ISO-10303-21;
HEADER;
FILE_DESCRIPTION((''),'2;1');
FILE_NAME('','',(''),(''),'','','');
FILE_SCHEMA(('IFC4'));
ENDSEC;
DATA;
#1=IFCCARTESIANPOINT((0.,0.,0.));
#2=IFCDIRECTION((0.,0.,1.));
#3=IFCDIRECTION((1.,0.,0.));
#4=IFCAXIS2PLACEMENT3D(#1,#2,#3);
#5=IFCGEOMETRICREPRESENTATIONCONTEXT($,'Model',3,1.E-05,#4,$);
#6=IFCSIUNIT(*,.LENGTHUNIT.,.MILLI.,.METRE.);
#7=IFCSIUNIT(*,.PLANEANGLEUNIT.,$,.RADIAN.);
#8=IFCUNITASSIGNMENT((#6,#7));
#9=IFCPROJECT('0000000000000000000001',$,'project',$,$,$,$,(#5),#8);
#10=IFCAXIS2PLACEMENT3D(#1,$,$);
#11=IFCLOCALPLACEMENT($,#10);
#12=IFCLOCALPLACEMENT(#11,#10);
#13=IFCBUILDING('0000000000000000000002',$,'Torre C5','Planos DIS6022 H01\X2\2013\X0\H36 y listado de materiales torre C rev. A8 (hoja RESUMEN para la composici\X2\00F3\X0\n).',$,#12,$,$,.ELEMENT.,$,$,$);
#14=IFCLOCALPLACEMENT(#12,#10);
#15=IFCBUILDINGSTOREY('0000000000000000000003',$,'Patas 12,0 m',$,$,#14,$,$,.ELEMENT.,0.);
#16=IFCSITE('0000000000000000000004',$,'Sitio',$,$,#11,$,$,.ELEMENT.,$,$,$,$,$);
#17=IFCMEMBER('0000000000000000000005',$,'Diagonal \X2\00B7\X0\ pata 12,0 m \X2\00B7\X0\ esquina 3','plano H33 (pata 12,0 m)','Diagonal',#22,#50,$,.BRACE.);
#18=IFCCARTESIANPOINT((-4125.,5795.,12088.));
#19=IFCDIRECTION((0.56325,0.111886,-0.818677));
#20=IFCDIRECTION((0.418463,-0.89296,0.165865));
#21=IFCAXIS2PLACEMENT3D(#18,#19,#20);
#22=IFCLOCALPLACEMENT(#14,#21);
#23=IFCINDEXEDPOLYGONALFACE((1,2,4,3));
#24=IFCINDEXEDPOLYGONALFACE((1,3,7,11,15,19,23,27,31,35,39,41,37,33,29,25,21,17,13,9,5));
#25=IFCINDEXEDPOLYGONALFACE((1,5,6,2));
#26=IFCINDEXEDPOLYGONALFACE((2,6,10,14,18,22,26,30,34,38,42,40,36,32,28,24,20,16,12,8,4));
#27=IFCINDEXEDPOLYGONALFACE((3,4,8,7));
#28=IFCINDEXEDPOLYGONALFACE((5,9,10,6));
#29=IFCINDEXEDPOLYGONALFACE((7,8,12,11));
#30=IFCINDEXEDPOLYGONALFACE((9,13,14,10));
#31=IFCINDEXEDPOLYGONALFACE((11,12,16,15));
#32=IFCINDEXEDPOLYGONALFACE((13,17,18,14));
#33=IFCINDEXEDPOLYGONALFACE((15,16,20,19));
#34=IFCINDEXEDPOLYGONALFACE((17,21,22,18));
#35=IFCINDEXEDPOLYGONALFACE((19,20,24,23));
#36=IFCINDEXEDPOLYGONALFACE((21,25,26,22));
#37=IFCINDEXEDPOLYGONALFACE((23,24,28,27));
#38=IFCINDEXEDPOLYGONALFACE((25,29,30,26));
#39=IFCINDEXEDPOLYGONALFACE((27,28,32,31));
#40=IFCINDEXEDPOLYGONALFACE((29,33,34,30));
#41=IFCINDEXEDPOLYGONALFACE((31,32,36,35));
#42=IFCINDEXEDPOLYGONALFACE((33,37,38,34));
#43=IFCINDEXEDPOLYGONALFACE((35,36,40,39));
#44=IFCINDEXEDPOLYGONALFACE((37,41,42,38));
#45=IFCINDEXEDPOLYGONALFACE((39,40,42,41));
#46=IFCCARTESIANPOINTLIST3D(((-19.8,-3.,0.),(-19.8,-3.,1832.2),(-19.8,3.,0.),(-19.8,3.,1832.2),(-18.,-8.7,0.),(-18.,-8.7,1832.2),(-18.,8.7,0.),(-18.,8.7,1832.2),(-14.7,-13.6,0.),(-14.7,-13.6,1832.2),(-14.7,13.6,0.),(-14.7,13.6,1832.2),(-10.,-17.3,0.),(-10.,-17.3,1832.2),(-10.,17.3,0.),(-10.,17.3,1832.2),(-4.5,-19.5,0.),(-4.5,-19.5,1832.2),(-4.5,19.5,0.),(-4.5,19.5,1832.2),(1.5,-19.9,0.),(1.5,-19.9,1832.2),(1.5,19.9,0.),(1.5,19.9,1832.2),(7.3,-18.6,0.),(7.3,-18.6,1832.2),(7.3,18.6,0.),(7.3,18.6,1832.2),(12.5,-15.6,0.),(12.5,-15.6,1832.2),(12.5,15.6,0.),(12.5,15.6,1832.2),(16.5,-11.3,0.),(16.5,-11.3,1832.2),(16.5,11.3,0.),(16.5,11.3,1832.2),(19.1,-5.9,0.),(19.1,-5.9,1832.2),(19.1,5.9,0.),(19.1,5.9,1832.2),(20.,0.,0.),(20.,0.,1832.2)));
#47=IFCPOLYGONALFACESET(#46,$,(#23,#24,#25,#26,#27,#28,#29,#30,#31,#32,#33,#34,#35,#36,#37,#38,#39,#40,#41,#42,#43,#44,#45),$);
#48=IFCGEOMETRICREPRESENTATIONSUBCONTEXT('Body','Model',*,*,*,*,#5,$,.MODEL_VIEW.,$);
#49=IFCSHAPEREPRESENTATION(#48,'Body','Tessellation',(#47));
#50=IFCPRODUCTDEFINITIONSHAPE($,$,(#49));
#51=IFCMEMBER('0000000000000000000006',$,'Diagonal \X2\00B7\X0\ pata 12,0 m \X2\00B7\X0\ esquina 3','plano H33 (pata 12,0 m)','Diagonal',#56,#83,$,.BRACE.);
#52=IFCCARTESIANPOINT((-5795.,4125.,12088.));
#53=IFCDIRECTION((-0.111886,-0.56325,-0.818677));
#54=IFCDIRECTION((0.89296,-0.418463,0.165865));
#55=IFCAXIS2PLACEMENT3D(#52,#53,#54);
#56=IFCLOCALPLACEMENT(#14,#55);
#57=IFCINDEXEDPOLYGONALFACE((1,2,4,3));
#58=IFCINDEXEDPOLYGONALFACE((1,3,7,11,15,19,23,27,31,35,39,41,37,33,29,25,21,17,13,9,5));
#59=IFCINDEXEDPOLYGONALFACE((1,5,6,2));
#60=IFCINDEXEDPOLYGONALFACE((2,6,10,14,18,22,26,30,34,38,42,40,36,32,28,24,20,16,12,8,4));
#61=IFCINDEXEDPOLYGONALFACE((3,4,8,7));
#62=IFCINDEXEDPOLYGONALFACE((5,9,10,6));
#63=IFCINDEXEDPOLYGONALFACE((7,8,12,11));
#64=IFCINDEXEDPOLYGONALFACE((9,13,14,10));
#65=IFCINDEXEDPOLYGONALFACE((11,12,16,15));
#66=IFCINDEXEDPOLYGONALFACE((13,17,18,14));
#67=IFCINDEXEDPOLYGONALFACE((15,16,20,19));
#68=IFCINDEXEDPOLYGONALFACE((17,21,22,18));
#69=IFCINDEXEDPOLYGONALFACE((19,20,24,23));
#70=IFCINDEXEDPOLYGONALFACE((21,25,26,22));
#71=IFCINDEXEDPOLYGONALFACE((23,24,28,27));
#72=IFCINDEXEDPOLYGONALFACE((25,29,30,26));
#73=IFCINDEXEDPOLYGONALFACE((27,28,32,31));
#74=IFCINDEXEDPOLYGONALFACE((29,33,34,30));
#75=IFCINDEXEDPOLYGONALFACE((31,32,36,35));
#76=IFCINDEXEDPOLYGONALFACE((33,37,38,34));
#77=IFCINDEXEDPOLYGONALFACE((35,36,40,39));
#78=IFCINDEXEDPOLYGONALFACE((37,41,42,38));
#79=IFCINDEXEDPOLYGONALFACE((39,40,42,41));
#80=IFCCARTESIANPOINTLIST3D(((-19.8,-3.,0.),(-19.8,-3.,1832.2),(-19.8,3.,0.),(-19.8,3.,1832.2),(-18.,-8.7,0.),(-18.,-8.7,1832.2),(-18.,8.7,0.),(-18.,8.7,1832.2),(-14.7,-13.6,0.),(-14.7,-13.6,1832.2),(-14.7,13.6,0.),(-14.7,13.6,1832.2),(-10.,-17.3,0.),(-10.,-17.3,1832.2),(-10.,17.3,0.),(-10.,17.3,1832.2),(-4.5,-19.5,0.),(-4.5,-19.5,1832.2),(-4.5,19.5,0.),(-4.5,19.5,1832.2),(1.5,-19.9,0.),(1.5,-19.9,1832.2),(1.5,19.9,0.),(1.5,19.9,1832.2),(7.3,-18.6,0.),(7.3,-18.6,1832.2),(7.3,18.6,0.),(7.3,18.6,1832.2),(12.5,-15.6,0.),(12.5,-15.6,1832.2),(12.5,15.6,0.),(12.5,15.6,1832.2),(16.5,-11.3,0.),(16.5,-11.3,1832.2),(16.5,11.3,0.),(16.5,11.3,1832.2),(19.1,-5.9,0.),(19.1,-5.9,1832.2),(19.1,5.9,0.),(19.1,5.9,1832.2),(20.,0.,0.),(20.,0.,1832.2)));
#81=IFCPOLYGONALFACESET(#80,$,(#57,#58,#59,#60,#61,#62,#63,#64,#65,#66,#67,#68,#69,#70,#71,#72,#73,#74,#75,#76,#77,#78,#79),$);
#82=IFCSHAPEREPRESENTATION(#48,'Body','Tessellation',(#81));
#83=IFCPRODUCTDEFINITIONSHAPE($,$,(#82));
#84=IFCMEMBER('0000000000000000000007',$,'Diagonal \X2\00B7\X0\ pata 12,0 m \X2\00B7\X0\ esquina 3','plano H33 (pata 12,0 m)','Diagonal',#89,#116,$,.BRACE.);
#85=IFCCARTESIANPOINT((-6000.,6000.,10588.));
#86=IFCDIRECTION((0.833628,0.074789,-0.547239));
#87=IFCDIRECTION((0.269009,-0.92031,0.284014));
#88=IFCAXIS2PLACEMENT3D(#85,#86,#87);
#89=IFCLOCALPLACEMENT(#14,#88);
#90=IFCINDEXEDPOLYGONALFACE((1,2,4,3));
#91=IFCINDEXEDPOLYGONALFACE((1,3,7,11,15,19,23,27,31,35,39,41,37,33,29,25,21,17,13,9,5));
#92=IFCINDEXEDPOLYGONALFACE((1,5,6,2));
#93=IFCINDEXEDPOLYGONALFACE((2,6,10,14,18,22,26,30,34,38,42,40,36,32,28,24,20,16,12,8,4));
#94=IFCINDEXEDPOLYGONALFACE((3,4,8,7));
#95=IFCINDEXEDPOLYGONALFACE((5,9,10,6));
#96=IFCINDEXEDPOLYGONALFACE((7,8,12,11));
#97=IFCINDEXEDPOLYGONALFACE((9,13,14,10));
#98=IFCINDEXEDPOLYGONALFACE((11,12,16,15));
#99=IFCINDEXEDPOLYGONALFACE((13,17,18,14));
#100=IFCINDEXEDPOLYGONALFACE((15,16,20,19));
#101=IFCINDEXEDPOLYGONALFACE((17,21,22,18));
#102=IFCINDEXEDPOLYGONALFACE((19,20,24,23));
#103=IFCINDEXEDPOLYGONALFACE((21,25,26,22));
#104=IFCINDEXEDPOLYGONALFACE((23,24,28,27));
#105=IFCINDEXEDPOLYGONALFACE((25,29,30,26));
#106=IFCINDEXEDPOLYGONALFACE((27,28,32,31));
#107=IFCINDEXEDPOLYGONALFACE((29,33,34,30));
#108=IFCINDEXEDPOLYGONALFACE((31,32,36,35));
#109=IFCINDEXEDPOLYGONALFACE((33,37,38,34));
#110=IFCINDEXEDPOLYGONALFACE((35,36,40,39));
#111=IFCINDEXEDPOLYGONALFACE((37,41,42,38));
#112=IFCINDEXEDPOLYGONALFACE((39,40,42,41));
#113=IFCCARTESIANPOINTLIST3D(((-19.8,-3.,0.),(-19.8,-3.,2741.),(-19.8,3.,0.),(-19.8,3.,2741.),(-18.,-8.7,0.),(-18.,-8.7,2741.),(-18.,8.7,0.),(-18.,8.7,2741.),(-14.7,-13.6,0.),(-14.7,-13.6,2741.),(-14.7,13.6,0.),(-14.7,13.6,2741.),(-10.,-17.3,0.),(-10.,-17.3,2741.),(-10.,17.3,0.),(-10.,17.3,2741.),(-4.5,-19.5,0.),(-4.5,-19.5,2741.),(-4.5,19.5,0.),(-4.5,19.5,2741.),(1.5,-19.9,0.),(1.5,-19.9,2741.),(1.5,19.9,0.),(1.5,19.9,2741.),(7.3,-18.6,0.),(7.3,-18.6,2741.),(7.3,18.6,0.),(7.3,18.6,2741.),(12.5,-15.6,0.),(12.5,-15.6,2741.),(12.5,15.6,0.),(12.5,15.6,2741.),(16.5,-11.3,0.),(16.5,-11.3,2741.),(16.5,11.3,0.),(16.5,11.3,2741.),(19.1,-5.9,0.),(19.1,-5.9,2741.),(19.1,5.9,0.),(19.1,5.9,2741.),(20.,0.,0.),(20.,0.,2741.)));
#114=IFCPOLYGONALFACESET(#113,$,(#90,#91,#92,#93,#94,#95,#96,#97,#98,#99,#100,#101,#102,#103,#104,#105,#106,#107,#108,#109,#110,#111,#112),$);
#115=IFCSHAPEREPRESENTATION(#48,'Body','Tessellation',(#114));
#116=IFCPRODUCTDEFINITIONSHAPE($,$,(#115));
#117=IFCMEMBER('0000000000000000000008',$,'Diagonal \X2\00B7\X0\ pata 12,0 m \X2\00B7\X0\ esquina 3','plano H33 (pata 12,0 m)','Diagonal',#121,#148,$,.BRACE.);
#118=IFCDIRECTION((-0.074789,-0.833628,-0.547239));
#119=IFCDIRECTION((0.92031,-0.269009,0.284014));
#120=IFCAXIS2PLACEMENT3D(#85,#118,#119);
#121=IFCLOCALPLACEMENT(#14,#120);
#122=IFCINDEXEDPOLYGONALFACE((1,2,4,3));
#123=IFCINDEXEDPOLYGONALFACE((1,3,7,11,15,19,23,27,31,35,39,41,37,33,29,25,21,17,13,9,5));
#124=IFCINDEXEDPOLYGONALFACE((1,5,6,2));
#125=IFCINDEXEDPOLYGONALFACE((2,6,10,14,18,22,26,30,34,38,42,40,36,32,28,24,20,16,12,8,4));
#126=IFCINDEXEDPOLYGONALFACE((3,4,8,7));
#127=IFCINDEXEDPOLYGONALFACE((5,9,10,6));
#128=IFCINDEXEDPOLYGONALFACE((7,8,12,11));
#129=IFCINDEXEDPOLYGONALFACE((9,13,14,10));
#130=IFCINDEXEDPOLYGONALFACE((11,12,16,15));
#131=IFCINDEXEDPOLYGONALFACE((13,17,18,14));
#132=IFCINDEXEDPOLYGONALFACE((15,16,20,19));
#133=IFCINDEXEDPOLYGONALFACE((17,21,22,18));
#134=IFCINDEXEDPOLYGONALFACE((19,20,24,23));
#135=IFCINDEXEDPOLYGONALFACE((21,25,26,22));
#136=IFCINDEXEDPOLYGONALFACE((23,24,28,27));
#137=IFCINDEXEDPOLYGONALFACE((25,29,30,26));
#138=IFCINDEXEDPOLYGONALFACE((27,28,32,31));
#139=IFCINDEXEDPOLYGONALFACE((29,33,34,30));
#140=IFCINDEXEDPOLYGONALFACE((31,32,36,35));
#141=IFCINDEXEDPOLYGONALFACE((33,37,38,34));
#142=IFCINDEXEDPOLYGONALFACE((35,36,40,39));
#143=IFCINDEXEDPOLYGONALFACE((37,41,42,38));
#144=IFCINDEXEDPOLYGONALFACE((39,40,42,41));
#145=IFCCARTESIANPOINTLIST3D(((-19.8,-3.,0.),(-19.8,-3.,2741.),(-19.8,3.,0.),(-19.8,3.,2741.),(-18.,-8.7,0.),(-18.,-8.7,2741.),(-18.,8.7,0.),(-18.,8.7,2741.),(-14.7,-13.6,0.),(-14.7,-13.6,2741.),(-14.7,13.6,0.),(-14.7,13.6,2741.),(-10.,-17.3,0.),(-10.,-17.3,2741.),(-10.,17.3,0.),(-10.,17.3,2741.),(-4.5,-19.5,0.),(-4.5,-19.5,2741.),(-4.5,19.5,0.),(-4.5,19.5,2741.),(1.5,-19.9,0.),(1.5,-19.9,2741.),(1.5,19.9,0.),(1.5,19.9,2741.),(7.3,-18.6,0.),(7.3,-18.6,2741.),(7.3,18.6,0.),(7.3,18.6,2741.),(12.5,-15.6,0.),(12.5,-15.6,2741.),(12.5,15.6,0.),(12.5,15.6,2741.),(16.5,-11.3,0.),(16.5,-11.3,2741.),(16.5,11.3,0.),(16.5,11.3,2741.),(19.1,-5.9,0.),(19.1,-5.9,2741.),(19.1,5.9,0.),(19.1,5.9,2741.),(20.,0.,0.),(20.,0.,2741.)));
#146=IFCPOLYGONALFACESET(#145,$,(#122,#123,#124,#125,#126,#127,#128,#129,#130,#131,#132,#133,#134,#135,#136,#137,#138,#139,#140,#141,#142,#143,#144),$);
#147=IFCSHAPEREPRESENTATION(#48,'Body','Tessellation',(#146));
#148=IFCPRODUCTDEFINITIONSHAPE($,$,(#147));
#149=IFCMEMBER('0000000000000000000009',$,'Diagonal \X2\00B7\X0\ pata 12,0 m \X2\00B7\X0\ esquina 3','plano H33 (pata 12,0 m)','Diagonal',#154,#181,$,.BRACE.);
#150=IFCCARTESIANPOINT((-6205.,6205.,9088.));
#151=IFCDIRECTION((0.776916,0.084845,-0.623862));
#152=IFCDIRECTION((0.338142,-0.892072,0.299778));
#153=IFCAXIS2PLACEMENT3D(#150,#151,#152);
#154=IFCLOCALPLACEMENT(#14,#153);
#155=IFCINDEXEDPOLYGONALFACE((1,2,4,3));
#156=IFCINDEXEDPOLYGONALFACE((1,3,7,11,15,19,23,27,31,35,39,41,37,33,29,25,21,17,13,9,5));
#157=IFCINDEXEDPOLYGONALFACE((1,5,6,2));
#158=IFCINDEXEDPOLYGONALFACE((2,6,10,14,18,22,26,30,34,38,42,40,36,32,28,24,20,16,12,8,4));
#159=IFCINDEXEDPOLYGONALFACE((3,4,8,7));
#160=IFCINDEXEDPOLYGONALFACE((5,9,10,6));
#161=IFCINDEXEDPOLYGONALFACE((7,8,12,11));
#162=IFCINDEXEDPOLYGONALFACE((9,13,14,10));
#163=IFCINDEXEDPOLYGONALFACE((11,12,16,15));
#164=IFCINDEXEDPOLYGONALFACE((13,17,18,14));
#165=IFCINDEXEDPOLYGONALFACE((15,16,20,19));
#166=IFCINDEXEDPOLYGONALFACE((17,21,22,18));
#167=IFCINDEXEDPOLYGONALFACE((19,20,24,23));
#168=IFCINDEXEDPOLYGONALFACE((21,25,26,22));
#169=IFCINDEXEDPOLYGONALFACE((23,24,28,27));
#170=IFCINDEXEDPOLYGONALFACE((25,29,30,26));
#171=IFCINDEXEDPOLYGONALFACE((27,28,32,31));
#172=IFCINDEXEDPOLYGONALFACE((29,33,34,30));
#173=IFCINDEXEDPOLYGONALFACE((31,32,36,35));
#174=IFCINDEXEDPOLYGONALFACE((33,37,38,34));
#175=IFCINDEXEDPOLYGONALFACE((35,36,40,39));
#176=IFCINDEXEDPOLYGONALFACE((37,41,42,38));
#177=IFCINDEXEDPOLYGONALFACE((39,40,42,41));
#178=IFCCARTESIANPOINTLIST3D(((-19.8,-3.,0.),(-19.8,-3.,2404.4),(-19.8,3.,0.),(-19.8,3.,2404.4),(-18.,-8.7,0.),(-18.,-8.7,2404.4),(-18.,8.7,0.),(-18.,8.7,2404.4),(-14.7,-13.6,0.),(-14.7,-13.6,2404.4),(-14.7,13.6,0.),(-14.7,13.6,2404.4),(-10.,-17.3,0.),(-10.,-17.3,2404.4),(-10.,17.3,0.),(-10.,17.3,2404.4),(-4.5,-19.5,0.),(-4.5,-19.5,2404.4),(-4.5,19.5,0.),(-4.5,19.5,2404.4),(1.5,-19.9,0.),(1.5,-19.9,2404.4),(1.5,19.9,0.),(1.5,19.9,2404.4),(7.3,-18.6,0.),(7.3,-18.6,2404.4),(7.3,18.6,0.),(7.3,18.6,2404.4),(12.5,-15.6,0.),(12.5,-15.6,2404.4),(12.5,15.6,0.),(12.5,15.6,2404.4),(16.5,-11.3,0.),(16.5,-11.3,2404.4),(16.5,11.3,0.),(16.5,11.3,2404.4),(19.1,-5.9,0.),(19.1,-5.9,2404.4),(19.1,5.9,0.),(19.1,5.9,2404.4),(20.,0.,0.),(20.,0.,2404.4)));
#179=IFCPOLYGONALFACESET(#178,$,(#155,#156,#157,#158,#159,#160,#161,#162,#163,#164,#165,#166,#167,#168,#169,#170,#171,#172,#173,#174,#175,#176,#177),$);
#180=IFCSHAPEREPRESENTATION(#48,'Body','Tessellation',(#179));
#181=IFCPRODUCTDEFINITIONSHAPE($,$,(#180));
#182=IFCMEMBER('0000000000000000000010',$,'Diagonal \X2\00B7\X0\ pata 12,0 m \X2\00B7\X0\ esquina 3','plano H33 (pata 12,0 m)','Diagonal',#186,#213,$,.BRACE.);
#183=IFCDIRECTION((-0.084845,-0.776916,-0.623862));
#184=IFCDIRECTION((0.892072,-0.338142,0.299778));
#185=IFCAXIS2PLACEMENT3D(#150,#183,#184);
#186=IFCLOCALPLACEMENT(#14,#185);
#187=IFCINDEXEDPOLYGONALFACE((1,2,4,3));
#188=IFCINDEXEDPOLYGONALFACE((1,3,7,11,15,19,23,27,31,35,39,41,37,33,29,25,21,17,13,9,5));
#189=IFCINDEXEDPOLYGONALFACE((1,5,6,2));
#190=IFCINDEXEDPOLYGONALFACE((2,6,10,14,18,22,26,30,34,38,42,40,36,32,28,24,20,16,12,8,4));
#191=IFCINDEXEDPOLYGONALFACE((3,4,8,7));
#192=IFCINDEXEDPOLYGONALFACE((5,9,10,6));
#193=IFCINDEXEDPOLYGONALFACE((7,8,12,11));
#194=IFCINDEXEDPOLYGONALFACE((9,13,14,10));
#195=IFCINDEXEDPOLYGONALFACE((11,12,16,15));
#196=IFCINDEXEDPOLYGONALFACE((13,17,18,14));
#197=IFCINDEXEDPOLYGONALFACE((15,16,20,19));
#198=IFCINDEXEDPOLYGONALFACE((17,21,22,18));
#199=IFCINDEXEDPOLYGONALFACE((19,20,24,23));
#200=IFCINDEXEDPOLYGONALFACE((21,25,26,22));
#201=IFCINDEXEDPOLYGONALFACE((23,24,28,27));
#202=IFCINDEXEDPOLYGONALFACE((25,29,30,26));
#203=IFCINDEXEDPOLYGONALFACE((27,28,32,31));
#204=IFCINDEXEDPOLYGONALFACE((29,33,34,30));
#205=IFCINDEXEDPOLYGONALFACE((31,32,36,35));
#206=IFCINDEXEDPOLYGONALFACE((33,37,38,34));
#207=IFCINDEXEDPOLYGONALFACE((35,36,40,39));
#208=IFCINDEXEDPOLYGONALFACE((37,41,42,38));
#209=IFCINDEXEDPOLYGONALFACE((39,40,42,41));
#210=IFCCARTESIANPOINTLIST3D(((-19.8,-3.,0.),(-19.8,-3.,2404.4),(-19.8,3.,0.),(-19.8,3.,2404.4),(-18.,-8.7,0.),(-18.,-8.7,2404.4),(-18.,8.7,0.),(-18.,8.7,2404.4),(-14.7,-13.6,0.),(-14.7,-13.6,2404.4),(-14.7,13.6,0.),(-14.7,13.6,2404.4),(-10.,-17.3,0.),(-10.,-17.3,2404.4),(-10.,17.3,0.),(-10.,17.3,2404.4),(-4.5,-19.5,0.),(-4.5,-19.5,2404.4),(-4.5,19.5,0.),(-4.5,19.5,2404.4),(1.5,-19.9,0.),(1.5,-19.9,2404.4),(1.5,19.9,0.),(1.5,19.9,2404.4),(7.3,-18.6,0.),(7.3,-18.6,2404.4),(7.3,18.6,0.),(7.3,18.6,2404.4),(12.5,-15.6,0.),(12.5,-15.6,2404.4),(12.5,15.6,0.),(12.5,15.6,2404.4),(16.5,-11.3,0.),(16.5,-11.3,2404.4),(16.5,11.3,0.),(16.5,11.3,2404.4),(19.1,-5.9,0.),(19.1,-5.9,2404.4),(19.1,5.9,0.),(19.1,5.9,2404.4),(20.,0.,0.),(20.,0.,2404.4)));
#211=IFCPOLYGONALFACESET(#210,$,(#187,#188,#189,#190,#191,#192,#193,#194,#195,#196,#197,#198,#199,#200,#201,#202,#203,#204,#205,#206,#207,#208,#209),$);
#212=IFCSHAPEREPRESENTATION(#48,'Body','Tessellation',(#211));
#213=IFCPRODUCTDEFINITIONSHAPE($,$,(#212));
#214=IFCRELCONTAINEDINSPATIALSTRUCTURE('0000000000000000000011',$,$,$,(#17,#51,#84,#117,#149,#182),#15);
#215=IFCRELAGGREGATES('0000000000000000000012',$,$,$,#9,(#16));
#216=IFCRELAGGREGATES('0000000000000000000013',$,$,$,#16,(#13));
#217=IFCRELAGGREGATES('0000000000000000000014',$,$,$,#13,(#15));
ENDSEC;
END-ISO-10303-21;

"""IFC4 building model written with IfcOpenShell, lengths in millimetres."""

from ifc_helpers import new_model, si_unit, frame, origin, origin_with_axes, place, context, subcontext, project, spatial, circle, extrude, element, save


model = new_model("IFC4")

# Units and contexts
model_context = context("Model", 3, precision=1e-05, world=origin_with_axes())
body_context = subcontext(model_context, "Body", "Model", "MODEL_VIEW")
ifc_project = project(units=[si_unit("LENGTHUNIT", "METRE", prefix="MILLI"), si_unit("PLANEANGLEUNIT", "RADIAN")], contexts=[model_context])

# Site, building, storey
site_placement = place(None, origin())
site = spatial("IfcSite", under=ifc_project, at=site_placement, Name="Sitio", CompositionType="ELEMENT")
building_placement = place(site_placement, origin())
building = spatial("IfcBuilding", under=site, at=building_placement, Name="Torre C5", Description="Planos DIS6022 H01–H36 y listado de materiales torre C rev. A8 (hoja RESUMEN para la composición).", CompositionType="ELEMENT")
storey_placement = place(building_placement, origin())
storey = spatial("IfcBuildingStorey", under=building, at=storey_placement, Name="Patas 12,0 m", CompositionType="ELEMENT", Elevation=0.0)

# Members
for number, where, z_axis, x_axis, name in (
    (1, (-4125.0, 5795.0, 12088.0), (0.56325, 0.111886, -0.818677), (0.418463, -0.89296, 0.165865), "Diagonal · pata 12,0 m · esquina 3"),
    (2, (-5795.0, 4125.0, 12088.0), (-0.111886, -0.56325, -0.818677), (0.89296, -0.418463, 0.165865), "Diagonal · pata 12,0 m · esquina 3"),
):
    element("IfcMember", number, at=place(storey_placement, frame(where, z_axis=z_axis, x_axis=x_axis)), inside=storey, Name=name, Description="plano H33 (pata 12,0 m)", ObjectType="Diagonal", PredefinedType="BRACE", context=body_context, shape_type="SweptSolid", body=[
        extrude(circle(Radius=20.0), None, (0.0, 0.0, 1.0), 1832.2),
    ])
for number, where, z_axis, x_axis, name in (
    (3, (-6000.0, 6000.0, 10588.0), (0.833628, 0.074789, -0.547239), (0.269009, -0.92031, 0.284014), "Diagonal · pata 12,0 m · esquina 3"),
    (4, (-6000.0, 6000.0, 10588.0), (-0.074789, -0.833628, -0.547239), (0.92031, -0.269009, 0.284014), "Diagonal · pata 12,0 m · esquina 3"),
):
    element("IfcMember", number, at=place(storey_placement, frame(where, z_axis=z_axis, x_axis=x_axis)), inside=storey, Name=name, Description="plano H33 (pata 12,0 m)", ObjectType="Diagonal", PredefinedType="BRACE", context=body_context, shape_type="SweptSolid", body=[
        extrude(circle(Radius=20.0), None, (0.0, 0.0, 1.0), 2741.0),
    ])
for number, where, z_axis, x_axis, name in (
    (5, (-6205.0, 6205.0, 9088.0), (0.776916, 0.084845, -0.623862), (0.338142, -0.892072, 0.299778), "Diagonal · pata 12,0 m · esquina 3"),
    (6, (-6205.0, 6205.0, 9088.0), (-0.084845, -0.776916, -0.623862), (0.892072, -0.338142, 0.299778), "Diagonal · pata 12,0 m · esquina 3"),
):
    element("IfcMember", number, at=place(storey_placement, frame(where, z_axis=z_axis, x_axis=x_axis)), inside=storey, Name=name, Description="plano H33 (pata 12,0 m)", ObjectType="Diagonal", PredefinedType="BRACE", context=body_context, shape_type="SweptSolid", body=[
        extrude(circle(Radius=20.0), None, (0.0, 0.0, 1.0), 2404.4),
    ])

save(model, "model.ifc")
